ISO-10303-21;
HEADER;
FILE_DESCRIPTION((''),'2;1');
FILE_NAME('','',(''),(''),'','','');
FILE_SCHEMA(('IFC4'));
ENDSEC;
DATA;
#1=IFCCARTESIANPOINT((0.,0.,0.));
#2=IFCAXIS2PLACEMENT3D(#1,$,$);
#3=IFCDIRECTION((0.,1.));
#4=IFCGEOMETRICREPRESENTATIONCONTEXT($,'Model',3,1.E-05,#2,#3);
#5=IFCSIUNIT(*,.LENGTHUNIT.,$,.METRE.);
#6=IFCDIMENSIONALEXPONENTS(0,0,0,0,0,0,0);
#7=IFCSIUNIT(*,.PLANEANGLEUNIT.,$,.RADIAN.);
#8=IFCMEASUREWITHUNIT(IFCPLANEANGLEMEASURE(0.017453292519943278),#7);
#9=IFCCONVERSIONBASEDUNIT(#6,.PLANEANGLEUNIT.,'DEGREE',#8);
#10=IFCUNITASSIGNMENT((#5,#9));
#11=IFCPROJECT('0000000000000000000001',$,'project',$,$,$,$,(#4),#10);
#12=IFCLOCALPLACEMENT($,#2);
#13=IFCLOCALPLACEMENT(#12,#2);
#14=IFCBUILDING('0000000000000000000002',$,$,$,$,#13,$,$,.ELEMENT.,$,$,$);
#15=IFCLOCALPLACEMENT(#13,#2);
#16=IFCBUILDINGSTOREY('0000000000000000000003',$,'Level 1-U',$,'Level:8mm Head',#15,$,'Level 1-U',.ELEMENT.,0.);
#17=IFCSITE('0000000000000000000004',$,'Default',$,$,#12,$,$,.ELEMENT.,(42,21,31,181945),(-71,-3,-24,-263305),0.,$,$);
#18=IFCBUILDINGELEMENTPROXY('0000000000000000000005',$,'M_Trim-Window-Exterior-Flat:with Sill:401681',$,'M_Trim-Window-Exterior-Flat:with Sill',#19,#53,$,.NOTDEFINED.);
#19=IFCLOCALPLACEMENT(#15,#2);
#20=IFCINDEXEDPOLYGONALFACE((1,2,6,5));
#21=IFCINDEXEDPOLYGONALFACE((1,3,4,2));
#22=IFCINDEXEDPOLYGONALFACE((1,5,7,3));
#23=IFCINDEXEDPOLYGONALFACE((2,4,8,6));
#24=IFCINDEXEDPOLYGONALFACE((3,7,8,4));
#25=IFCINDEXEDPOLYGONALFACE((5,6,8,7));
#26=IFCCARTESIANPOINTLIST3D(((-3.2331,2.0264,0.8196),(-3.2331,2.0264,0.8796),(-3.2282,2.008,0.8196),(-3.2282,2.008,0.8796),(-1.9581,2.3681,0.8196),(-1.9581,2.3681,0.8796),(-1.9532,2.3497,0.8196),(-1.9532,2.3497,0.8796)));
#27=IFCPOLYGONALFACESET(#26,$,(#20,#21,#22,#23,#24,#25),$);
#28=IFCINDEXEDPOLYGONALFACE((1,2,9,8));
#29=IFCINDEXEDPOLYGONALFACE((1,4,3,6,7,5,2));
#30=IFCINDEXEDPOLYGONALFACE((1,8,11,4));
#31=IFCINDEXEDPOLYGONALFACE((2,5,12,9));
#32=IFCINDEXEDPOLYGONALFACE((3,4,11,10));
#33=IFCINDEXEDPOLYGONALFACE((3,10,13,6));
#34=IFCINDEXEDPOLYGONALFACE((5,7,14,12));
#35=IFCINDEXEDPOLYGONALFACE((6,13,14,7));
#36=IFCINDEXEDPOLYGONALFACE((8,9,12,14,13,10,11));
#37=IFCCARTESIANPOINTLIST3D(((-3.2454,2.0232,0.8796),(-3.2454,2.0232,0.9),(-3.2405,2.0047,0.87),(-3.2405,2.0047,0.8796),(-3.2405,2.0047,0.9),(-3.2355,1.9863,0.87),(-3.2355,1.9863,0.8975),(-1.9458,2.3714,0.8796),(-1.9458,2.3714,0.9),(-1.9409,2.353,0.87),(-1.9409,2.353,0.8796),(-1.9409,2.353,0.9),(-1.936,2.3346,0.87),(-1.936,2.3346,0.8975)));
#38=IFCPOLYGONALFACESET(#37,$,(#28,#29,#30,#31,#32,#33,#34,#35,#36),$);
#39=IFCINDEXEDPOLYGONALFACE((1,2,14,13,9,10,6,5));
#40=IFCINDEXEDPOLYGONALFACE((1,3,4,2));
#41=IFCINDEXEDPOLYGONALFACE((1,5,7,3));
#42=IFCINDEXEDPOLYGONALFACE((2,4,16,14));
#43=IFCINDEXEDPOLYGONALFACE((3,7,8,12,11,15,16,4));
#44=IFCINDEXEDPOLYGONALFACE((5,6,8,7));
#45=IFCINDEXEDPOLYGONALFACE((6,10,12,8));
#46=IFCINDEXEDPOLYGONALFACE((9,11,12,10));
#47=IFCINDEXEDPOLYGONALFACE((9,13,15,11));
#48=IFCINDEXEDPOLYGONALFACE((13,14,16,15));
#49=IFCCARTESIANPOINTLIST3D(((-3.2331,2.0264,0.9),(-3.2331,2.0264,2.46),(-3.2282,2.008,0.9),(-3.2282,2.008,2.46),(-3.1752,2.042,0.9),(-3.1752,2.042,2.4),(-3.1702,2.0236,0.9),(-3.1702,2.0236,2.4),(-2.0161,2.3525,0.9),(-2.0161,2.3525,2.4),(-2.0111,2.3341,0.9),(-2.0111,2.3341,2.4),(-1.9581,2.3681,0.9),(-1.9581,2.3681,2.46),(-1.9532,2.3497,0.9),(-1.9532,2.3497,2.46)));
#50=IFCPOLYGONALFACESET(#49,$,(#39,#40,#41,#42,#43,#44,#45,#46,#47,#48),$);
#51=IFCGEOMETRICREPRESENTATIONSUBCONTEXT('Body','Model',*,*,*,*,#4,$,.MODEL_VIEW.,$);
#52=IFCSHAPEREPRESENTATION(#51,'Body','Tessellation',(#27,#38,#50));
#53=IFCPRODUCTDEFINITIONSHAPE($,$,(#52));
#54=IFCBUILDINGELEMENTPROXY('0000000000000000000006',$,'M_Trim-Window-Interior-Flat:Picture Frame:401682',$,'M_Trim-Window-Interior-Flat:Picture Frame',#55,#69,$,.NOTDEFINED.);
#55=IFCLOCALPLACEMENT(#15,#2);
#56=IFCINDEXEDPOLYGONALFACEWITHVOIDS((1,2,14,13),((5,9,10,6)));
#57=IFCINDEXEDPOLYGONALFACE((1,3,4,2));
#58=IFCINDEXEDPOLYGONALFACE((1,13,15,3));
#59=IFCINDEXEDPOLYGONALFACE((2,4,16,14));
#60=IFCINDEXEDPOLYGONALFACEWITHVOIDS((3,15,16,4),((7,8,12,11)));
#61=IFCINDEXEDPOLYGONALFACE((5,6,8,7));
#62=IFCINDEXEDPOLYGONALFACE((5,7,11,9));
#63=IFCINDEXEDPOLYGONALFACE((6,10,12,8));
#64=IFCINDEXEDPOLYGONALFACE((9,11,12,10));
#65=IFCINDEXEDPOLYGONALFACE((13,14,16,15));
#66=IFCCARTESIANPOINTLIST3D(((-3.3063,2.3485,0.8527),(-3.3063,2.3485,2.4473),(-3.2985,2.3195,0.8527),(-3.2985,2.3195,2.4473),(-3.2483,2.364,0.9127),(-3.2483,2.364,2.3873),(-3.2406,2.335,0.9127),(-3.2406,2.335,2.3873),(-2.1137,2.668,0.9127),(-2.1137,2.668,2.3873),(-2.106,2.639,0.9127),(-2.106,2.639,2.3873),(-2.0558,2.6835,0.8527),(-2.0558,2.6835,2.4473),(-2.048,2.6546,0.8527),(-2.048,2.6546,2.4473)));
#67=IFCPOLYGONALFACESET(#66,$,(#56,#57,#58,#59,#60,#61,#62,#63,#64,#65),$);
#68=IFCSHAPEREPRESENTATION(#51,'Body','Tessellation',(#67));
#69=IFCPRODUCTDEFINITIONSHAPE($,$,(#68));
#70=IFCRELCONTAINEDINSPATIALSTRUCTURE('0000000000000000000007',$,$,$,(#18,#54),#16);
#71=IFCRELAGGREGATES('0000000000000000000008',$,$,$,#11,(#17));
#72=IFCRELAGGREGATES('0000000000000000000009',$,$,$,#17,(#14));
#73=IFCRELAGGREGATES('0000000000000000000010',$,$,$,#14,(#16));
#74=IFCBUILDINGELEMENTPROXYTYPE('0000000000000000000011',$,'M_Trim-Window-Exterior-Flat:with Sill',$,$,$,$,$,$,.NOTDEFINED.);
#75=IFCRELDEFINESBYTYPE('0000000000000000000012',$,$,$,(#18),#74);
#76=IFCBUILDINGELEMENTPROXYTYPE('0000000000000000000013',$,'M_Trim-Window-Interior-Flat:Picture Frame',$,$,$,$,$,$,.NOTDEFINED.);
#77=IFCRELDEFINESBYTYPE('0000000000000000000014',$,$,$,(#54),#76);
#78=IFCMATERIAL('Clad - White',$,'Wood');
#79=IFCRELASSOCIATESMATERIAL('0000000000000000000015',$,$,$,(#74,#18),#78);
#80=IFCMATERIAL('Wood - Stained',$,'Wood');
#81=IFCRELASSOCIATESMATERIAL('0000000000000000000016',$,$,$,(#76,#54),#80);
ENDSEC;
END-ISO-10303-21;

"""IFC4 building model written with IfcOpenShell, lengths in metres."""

from ifc_helpers import new_model, entity, si_unit, converted_unit, direction, frame, origin, place, context, subcontext, project, spatial, indexed_curve, outline, extrude, source, transform, mapped, material, type_object, type_shapes, element, save


model = new_model("IFC4")

# Units and contexts
model_context = context("Model", 3, precision=1e-05, world=origin(), true_north=direction((0.0, 1.0)))
body_context = subcontext(model_context, "Body", "Model", "MODEL_VIEW")
ifc_project = project(units=[si_unit("LENGTHUNIT", "METRE"), converted_unit("PLANEANGLEUNIT", "DEGREE", entity("IfcPlaneAngleMeasure", 0.017453292519943278), si_unit("PLANEANGLEUNIT", "RADIAN"), dimensions=[0, 0, 0, 0, 0, 0, 0])], contexts=[model_context])

# Site, building, storey
site_placement = place(None, origin())
site = spatial("IfcSite", under=ifc_project, at=site_placement, Name="Default", CompositionType="ELEMENT", RefLatitude=(42, 21, 31, 181945), RefLongitude=(-71, -3, -24, -263305), RefElevation=0.0)
building_placement = place(site_placement, origin())
building = spatial("IfcBuilding", under=site, at=building_placement, CompositionType="ELEMENT")
storey_placement = place(building_placement, origin())
storey = spatial("IfcBuildingStorey", under=building, at=storey_placement, Name="Level 1-U", ObjectType="Level:8mm Head", LongName="Level 1-U", CompositionType="ELEMENT", Elevation=0.0)

# Building element proxies
ifc_material_1 = material(Name="Clad - White", Category="Wood")
ifc_material_2 = material(Name="Wood - Stained", Category="Wood")
building_element_proxy_type_1 = type_object("IfcBuildingElementProxyType", Name="M_Trim-Window-Exterior-Flat:with Sill", PredefinedType="NOTDEFINED", material=ifc_material_1)
shared_shape_1 = source(origin(), body_context, "Body", "SweptSolid", [
    extrude(outline(indexed_curve([(-0.66, -0.03), (0.66, -0.03), (0.66, 0.03), (-0.66, 0.03), (-0.66, -0.03)], self_intersect=False)), frame((0.0, -1.5504, 0.0), z_axis=(0.0, 0.0, 1.0), x_axis=(-1.0, 0.0, 0.0)), (0.0, 0.0, 1.0), 0.019),
    extrude(outline(indexed_curve([(-0.019, -0.0152), (0.0, -0.0152), (0.0, -0.0057), (0.019, -0.0057), (0.019, 0.0148), (0.0, 0.0148), (-0.019, 0.0123), (-0.019, -0.0152)], self_intersect=False)), frame((-0.6727, -1.5148, 0.019), z_axis=(1.0, 0.0, 0.0), x_axis=(0.0, 0.0, -1.0)), (0.0, 0.0, 1.0), 1.3454),
    extrude(outline(indexed_curve([(-0.795, -0.66), (0.765, -0.66), (0.765, -0.6), (-0.735, -0.6), (-0.735, 0.6), (0.765, 0.6), (0.765, 0.66), (-0.795, 0.66), (-0.795, -0.66)], self_intersect=False)), frame((0.0, -0.735, 0.0), z_axis=(0.0, 0.0, 1.0), x_axis=(0.0, -1.0, 0.0)), (0.0, 0.0, 1.0), 0.019),
])
type_shapes(building_element_proxy_type_1, [shared_shape_1])
proxy_1_placement = place(storey_placement, frame((-2.5956, 2.1973, 2.4), z_axis=(0.258819, -0.965926, 0.0), x_axis=(0.965926, 0.258819, 0.0)))
element("IfcBuildingElementProxy", 1, at=proxy_1_placement, inside=storey, type_object=building_element_proxy_type_1, material=ifc_material_1, Name="M_Trim-Window-Exterior-Flat:with Sill:401681", ObjectType="M_Trim-Window-Exterior-Flat:with Sill", PredefinedType="NOTDEFINED", context=body_context, shape_type="MappedRepresentation", body=[
    mapped(shared_shape_1, transform((0.0, 0.0, 0.0), scale=1.0)),
])
building_element_proxy_type_2 = type_object("IfcBuildingElementProxyType", Name="M_Trim-Window-Interior-Flat:Picture Frame", PredefinedType="NOTDEFINED", material=ifc_material_2)
shared_shape_2 = source(origin(), body_context, "Body", "SweptSolid", [
    extrude(outline(indexed_curve([(-0.6473, -0.7973), (0.6473, -0.7973), (0.6473, 0.7973), (-0.6473, 0.7973), (-0.6473, -0.7973)], self_intersect=False), holes=[indexed_curve([(-0.5873, -0.7373), (-0.5873, 0.7373), (0.5873, 0.7373), (0.5873, -0.7373), (-0.5873, -0.7373)], self_intersect=False)]), frame((0.0, -0.75, 0.0), z_axis=(0.0, 0.0, 1.0), x_axis=(-1.0, 0.0, 0.0)), (0.0, 0.0, 1.0), 0.03),
])
type_shapes(building_element_proxy_type_2, [shared_shape_2])
proxy_2_placement = place(storey_placement, frame((-2.6733, 2.487, 2.4), z_axis=(-0.258819, 0.965926, 0.0), x_axis=(-0.965926, -0.258819, 0.0)))
element("IfcBuildingElementProxy", 2, at=proxy_2_placement, inside=storey, type_object=building_element_proxy_type_2, material=ifc_material_2, Name="M_Trim-Window-Interior-Flat:Picture Frame:401682", ObjectType="M_Trim-Window-Interior-Flat:Picture Frame", PredefinedType="NOTDEFINED", context=body_context, shape_type="MappedRepresentation", body=[
    mapped(shared_shape_2, transform((0.0, 0.0, 0.0), scale=1.0)),
])

save(model, "model.ifc")
